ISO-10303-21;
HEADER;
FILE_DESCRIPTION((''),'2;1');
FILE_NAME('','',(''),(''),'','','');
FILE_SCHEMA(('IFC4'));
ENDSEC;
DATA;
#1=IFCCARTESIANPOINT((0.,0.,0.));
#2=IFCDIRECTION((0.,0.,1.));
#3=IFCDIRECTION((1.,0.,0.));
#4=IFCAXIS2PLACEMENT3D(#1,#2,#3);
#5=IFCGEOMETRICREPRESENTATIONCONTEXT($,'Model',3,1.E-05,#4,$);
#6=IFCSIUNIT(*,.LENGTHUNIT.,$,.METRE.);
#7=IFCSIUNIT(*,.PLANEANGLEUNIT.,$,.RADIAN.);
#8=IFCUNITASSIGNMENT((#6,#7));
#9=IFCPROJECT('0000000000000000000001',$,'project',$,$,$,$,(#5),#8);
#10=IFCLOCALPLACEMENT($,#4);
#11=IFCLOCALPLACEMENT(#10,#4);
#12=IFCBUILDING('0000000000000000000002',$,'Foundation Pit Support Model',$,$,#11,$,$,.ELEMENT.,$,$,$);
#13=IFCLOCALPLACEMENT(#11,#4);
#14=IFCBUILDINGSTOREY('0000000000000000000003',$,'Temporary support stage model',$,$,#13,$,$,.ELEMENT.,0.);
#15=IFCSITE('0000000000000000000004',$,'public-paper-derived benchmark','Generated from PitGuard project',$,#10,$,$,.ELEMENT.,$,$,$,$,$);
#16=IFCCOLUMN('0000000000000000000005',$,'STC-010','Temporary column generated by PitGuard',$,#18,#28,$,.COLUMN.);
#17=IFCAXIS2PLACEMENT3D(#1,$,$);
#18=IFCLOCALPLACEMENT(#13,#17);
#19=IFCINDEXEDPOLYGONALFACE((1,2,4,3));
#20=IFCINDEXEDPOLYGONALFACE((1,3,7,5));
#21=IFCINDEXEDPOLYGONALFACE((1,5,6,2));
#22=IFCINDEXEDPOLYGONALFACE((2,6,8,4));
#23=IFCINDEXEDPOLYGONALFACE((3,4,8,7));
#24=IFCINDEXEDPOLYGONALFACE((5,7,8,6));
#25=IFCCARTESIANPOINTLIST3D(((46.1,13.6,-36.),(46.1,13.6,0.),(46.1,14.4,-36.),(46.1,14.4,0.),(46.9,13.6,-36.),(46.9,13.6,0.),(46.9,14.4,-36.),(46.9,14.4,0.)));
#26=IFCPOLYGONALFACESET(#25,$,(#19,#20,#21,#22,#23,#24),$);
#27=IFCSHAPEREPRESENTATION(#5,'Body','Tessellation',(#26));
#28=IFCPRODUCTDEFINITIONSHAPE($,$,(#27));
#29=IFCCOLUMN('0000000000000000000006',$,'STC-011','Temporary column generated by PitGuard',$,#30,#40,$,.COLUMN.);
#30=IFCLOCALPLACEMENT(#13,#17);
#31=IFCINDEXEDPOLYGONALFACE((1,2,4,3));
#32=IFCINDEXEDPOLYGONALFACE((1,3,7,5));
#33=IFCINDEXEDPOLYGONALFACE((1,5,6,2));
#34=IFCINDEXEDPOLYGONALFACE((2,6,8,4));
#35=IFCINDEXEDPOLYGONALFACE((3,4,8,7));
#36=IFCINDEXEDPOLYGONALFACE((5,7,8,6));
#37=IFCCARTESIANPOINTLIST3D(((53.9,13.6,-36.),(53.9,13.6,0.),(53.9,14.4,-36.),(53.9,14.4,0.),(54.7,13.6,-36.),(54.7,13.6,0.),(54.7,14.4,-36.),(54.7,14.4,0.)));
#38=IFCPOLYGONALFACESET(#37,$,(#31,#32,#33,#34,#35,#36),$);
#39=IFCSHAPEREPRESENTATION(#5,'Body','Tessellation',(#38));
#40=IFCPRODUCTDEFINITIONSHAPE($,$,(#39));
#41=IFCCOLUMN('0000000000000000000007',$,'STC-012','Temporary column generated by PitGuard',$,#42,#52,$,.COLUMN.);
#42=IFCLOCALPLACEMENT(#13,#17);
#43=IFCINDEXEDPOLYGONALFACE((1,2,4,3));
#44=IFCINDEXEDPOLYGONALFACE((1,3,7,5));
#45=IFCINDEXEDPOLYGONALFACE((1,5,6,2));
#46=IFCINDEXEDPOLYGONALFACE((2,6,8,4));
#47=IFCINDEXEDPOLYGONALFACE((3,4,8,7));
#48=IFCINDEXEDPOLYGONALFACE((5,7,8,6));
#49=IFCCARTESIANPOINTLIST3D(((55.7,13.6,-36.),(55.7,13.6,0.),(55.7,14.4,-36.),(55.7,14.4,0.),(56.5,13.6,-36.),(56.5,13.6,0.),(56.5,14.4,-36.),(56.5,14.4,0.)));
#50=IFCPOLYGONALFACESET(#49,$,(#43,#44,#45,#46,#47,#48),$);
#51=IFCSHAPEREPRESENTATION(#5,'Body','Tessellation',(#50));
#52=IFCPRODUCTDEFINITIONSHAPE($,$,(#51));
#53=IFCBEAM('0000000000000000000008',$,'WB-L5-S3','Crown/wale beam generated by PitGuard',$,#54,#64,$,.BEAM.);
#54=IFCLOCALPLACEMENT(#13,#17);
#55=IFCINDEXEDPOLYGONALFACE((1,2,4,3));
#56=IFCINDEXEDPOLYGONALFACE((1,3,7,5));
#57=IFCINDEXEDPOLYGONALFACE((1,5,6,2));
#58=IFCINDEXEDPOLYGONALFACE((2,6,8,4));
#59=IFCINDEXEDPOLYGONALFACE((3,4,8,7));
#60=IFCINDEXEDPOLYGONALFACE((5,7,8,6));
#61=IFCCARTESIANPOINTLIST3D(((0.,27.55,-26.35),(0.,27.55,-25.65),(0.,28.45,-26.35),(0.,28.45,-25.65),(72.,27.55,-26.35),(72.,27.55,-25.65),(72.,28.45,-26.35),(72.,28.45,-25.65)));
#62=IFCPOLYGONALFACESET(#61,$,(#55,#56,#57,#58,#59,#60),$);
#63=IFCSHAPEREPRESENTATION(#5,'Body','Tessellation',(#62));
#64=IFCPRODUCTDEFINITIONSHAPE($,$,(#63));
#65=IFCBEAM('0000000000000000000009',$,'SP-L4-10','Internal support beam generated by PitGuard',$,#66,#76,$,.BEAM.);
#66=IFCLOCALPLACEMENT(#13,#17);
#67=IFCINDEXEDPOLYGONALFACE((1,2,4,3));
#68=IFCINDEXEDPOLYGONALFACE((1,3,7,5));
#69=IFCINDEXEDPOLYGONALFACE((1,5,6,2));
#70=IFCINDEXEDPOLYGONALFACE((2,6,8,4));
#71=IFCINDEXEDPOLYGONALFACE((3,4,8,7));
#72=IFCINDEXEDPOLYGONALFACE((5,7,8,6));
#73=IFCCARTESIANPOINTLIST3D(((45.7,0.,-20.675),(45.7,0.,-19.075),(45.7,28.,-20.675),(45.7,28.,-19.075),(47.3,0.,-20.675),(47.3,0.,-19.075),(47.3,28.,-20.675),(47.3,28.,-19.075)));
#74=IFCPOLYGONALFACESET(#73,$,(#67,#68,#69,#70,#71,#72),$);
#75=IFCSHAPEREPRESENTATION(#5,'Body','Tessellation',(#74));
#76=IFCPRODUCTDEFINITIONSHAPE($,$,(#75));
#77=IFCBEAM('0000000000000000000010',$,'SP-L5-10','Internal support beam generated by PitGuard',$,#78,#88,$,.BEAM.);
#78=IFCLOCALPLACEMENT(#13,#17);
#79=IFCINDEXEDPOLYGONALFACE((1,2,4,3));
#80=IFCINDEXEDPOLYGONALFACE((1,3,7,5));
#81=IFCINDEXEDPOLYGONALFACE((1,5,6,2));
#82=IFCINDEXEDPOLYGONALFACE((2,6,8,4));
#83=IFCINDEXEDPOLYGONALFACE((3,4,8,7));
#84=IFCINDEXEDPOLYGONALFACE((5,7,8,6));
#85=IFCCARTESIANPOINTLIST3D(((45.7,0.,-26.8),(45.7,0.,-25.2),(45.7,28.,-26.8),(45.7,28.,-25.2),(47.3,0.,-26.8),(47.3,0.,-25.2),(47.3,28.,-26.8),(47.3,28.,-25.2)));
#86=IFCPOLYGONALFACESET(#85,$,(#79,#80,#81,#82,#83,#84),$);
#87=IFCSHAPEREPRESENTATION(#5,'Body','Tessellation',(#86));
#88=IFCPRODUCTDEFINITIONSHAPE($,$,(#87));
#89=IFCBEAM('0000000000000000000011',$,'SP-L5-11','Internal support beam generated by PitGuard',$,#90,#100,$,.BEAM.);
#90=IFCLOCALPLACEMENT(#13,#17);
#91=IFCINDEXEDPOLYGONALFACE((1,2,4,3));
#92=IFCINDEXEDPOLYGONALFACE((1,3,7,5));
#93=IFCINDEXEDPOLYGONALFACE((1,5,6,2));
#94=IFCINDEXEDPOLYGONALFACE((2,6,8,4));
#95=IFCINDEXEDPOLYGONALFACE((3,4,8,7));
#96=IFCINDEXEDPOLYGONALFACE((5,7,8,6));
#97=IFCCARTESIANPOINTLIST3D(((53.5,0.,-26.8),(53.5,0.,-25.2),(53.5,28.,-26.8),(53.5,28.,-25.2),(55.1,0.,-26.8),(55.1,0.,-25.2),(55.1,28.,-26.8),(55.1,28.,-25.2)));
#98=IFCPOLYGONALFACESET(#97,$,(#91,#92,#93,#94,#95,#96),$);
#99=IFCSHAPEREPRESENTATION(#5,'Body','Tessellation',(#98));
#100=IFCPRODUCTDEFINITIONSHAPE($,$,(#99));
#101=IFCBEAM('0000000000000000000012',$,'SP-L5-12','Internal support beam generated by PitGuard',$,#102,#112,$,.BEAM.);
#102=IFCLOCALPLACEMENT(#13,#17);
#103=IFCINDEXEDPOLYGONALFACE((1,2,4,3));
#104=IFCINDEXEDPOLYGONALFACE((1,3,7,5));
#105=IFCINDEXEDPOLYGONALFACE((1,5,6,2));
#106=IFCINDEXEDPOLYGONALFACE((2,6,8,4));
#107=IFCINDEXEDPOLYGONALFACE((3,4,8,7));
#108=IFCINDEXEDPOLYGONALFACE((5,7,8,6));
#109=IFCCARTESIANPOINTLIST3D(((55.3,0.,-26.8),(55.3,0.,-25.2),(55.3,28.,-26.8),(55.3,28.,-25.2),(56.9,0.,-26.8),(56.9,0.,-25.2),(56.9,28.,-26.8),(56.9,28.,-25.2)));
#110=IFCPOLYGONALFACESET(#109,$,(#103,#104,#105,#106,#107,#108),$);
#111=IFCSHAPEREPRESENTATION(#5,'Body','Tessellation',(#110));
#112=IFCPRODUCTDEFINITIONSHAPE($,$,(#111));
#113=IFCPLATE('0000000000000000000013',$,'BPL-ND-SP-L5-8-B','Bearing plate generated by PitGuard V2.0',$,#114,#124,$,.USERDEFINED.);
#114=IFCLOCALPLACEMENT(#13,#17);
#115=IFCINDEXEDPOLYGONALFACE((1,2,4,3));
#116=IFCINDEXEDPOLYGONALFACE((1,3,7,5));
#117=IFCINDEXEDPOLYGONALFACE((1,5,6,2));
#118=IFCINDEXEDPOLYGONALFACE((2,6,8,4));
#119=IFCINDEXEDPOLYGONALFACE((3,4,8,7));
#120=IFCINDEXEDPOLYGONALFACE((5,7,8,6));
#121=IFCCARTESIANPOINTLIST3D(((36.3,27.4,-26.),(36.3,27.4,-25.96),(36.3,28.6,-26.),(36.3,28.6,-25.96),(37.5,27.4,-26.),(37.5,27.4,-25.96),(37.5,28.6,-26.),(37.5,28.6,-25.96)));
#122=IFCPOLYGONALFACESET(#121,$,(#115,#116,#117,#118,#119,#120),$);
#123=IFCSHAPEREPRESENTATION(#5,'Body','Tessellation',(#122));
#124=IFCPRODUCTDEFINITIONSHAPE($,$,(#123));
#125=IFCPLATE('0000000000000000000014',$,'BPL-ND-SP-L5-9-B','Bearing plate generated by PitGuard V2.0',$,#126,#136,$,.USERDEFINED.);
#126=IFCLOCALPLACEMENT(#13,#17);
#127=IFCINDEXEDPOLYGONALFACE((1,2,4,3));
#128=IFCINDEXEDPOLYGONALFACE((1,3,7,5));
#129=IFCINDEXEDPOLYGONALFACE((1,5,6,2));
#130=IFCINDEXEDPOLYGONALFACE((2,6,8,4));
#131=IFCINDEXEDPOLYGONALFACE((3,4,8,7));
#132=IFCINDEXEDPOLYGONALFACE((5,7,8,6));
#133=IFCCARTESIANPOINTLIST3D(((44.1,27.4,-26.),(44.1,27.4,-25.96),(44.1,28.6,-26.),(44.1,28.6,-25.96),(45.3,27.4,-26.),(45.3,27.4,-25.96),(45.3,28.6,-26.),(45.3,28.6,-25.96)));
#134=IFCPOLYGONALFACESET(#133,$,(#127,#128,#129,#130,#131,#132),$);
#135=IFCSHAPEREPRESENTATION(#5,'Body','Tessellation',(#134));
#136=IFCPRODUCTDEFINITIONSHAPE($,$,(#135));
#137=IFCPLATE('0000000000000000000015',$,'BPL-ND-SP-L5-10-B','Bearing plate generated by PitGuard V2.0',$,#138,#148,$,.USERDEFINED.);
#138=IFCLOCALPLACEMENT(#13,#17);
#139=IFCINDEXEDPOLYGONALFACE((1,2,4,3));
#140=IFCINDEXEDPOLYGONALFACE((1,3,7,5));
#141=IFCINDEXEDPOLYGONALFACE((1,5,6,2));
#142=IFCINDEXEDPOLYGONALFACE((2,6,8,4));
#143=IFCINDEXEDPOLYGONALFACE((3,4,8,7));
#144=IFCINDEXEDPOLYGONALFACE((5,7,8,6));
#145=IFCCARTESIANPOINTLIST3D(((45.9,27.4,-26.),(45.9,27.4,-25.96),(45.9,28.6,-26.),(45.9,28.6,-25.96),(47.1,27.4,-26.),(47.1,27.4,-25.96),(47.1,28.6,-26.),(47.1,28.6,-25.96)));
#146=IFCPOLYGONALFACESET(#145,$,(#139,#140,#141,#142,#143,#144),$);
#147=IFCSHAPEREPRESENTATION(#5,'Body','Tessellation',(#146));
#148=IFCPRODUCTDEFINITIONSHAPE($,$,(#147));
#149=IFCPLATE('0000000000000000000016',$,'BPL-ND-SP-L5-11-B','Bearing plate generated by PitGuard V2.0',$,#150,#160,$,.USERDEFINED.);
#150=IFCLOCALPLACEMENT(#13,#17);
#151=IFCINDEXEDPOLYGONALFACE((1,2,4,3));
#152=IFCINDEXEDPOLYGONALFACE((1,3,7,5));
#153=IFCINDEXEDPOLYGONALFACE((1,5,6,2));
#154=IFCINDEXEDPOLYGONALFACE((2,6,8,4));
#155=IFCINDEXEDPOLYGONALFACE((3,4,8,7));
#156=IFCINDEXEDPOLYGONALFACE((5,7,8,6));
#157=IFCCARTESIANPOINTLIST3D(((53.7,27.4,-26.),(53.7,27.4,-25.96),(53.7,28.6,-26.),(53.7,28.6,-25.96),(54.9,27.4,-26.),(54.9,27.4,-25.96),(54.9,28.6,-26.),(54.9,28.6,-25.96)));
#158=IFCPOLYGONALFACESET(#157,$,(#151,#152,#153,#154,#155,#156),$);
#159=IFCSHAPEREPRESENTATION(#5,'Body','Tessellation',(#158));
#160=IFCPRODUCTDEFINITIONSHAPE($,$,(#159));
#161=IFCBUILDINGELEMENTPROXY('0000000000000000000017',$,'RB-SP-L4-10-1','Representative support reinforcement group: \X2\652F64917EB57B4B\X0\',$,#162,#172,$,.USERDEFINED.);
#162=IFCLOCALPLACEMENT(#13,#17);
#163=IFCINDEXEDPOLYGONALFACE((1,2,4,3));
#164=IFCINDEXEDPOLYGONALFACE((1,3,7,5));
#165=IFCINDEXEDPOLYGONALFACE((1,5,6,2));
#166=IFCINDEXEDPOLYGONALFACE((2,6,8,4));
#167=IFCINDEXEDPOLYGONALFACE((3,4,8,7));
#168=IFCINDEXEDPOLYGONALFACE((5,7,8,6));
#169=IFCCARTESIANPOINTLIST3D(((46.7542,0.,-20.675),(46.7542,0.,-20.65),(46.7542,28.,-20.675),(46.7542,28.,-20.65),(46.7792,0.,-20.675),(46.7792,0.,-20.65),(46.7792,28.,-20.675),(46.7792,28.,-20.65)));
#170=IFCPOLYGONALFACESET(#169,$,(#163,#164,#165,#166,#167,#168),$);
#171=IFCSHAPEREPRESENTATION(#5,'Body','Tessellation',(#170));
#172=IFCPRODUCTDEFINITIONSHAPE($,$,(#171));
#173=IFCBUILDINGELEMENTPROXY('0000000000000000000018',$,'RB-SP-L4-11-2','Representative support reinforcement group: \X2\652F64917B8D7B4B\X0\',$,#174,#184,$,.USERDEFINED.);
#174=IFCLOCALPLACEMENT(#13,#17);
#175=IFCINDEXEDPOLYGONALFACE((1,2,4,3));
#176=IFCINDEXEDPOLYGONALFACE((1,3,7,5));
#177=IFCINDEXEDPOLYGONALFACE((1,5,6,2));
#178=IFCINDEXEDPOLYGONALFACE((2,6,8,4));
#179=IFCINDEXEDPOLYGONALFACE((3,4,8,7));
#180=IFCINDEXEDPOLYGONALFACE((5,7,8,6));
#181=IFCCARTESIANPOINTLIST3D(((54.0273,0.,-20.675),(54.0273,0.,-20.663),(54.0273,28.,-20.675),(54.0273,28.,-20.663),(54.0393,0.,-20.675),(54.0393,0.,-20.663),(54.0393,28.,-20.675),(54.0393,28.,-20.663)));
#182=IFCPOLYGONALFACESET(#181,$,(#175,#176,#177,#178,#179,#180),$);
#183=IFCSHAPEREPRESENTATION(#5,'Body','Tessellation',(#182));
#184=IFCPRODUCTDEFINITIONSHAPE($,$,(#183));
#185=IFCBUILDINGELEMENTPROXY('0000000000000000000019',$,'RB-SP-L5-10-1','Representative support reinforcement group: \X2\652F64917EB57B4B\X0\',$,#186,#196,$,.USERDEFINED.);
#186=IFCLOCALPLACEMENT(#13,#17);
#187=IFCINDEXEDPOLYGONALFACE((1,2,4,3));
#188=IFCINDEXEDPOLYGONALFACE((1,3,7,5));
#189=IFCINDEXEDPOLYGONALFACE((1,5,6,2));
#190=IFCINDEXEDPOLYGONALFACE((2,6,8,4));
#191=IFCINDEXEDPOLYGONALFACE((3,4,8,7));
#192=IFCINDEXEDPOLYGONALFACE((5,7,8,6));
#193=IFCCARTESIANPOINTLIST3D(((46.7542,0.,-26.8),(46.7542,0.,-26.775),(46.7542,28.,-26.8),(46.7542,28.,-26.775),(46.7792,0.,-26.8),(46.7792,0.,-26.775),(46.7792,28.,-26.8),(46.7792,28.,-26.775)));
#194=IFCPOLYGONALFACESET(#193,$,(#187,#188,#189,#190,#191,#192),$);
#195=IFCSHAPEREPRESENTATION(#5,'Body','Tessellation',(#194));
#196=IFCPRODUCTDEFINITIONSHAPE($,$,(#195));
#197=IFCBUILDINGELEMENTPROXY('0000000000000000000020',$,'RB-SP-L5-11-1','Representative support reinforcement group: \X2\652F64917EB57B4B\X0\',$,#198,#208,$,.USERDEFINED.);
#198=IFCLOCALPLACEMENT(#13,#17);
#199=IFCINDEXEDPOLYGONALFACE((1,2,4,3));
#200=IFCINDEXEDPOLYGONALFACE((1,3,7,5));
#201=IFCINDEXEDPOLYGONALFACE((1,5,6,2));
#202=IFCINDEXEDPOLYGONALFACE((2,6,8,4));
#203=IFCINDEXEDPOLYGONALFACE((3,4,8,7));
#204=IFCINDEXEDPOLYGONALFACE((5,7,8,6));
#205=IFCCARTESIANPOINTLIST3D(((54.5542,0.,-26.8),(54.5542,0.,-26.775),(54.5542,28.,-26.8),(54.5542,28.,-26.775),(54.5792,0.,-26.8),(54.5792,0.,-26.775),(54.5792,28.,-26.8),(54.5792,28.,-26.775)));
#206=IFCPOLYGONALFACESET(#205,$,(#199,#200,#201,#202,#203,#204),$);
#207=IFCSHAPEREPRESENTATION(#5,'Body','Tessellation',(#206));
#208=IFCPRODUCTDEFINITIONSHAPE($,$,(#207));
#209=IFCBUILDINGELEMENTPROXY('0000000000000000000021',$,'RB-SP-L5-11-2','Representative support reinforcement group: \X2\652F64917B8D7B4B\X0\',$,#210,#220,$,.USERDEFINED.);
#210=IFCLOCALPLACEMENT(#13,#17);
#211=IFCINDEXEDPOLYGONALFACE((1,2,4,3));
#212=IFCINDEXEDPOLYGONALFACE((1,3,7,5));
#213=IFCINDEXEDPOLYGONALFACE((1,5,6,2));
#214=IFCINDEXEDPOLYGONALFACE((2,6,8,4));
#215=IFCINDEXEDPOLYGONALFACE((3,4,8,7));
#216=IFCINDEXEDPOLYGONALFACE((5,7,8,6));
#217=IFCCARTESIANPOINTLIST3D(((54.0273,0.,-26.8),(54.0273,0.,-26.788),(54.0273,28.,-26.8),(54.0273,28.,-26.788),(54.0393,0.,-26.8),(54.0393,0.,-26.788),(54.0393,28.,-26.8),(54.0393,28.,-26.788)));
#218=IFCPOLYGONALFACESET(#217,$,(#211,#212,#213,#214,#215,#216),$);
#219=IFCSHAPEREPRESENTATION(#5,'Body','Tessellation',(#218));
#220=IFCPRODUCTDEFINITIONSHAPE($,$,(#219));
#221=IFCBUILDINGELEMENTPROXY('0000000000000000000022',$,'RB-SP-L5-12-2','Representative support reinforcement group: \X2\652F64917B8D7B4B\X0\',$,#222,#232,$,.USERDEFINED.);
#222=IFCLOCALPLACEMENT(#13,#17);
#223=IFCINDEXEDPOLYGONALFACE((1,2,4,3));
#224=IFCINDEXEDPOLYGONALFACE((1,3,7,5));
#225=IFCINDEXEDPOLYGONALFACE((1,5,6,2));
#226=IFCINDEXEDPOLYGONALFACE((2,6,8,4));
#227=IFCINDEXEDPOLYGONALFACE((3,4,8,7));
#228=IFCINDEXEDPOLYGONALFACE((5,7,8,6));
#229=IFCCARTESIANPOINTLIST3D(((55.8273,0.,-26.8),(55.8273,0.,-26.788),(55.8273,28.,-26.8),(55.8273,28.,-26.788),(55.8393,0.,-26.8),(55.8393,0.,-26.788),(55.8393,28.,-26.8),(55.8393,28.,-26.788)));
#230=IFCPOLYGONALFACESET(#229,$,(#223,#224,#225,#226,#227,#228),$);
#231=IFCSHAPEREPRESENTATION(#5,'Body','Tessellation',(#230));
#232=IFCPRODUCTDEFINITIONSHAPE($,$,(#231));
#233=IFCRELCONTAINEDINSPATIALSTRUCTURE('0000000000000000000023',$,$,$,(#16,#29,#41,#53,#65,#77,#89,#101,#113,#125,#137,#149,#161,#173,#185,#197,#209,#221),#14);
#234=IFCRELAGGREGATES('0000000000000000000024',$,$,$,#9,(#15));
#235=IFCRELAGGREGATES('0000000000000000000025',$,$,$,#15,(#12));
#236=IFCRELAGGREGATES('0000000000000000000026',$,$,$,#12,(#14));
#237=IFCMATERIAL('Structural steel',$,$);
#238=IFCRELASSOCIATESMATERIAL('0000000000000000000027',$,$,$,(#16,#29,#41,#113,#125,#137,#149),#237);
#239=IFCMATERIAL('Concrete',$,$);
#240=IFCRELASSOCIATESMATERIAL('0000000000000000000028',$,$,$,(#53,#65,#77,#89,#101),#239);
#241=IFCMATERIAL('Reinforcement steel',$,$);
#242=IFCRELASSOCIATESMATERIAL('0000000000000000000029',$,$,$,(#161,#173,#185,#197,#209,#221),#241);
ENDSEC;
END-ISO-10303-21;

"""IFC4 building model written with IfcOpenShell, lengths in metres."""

from ifc_helpers import new_model, si_unit, frame, origin_with_axes, origin_2d, place, context, project, spatial, rectangle, extrude, material, element, save


model = new_model("IFC4")

# Units and contexts
model_context = context("Model", 3, precision=1e-05, world=origin_with_axes())
ifc_project = project(units=[si_unit("LENGTHUNIT", "METRE"), si_unit("PLANEANGLEUNIT", "RADIAN")], contexts=[model_context])

# Site, building, storey
site_placement = place(None, origin_with_axes())
site = spatial("IfcSite", under=ifc_project, at=site_placement, Name="public-paper-derived benchmark", Description="Generated from PitGuard project", CompositionType="ELEMENT")
building_placement = place(site_placement, origin_with_axes())
building = spatial("IfcBuilding", under=site, at=building_placement, Name="Foundation Pit Support Model", CompositionType="ELEMENT")
storey_placement = place(building_placement, origin_with_axes())
storey = spatial("IfcBuildingStorey", under=building, at=storey_placement, Name="Temporary support stage model", CompositionType="ELEMENT", Elevation=0.0)

# Columns
ifc_material_1 = material(Name="Structural steel")
for number, where, z_axis, x_axis, name in (
    (1, (46.5, 14.0, -36.0), (0.0, 0.0, 1.0), (1.0, 0.0, 0.0), "STC-010"),
    (2, (54.3, 14.0, -36.0), (0.0, 0.0, 1.0), (1.0, 0.0, 0.0), "STC-011"),
    (3, (56.1, 14.0, -36.0), (0.0, 0.0, 1.0), (1.0, 0.0, 0.0), "STC-012"),
):
    element("IfcColumn", number, at=place(storey_placement, frame(where, z_axis=z_axis, x_axis=x_axis)), inside=storey, material=ifc_material_1, Name=name, Description="Temporary column generated by PitGuard", PredefinedType="COLUMN", context=model_context, shape_type="SweptSolid", body=[
        extrude(rectangle(XDim=0.8, YDim=0.8, at=origin_2d()), origin_with_axes(), (0.0, 0.0, 1.0), 36.0),
    ])

# Beams
ifc_material_2 = material(Name="Concrete")
beam_placement = place(storey_placement, frame((36.0, 28.0, -26.35), z_axis=(0.0, 0.0, 1.0), x_axis=(-1.0, 0.0, 0.0)))
element("IfcBeam", 4, at=beam_placement, inside=storey, material=ifc_material_2, Name="WB-L5-S3", Description="Crown/wale beam generated by PitGuard", PredefinedType="BEAM", context=model_context, shape_type="SweptSolid", body=[
    extrude(rectangle(XDim=72.0, YDim=0.9, at=origin_2d()), origin_with_axes(), (0.0, 0.0, 1.0), 0.7),
])
for number, where, z_axis, x_axis, name in (
    (5, (46.5, 14.0, -20.675), (0.0, 0.0, 1.0), (0.0, 1.0, 0.0), "SP-L4-10"),
    (6, (46.5, 14.0, -26.8), (0.0, 0.0, 1.0), (0.0, 1.0, 0.0), "SP-L5-10"),
    (7, (54.3, 14.0, -26.8), (0.0, 0.0, 1.0), (0.0, 1.0, 0.0), "SP-L5-11"),
    (8, (56.1, 14.0, -26.8), (0.0, 0.0, 1.0), (0.0, 1.0, 0.0), "SP-L5-12"),
):
    element("IfcBeam", number, at=place(storey_placement, frame(where, z_axis=z_axis, x_axis=x_axis)), inside=storey, material=ifc_material_2, Name=name, Description="Internal support beam generated by PitGuard", PredefinedType="BEAM", context=model_context, shape_type="SweptSolid", body=[
        extrude(rectangle(XDim=28.0, YDim=1.6, at=origin_2d()), origin_with_axes(), (0.0, 0.0, 1.0), 1.6),
    ])

# Plates
for number, where, z_axis, x_axis, name in (
    (9, (36.9, 28.0, -26.0), (0.0, 0.0, 1.0), (1.0, 0.0, 0.0), "BPL-ND-SP-L5-8-B"),
    (10, (44.7, 28.0, -26.0), (0.0, 0.0, 1.0), (1.0, 0.0, 0.0), "BPL-ND-SP-L5-9-B"),
    (11, (46.5, 28.0, -26.0), (0.0, 0.0, 1.0), (1.0, 0.0, 0.0), "BPL-ND-SP-L5-10-B"),
    (12, (54.3, 28.0, -26.0), (0.0, 0.0, 1.0), (1.0, 0.0, 0.0), "BPL-ND-SP-L5-11-B"),
):
    element("IfcPlate", number, at=place(storey_placement, frame(where, z_axis=z_axis, x_axis=x_axis)), inside=storey, material=ifc_material_1, Name=name, Description="Bearing plate generated by PitGuard V2.0", PredefinedType="USERDEFINED", context=model_context, shape_type="SweptSolid", body=[
        extrude(rectangle(XDim=1.2, YDim=1.2, at=origin_2d()), origin_with_axes(), (0.0, 0.0, 1.0), 0.04),
    ])

# Building element proxies
ifc_material_3 = material(Name="Reinforcement steel")
proxy_1_placement = place(storey_placement, frame((46.7667, 14.0, -20.675), z_axis=(0.0, 0.0, 1.0), x_axis=(0.0, 1.0, 0.0)))
element("IfcBuildingElementProxy", 13, at=proxy_1_placement, inside=storey, material=ifc_material_3, Name="RB-SP-L4-10-1", Description="Representative support reinforcement group: 支撑纵筋", PredefinedType="USERDEFINED", context=model_context, shape_type="SweptSolid", body=[
    extrude(rectangle(XDim=28.0, YDim=0.025, at=origin_2d()), origin_with_axes(), (0.0, 0.0, 1.0), 0.025),
])
proxy_2_placement = place(storey_placement, frame((54.0333, 14.0, -20.675), z_axis=(0.0, 0.0, 1.0), x_axis=(0.0, 1.0, 0.0)))
element("IfcBuildingElementProxy", 14, at=proxy_2_placement, inside=storey, material=ifc_material_3, Name="RB-SP-L4-11-2", Description="Representative support reinforcement group: 支撑箍筋", PredefinedType="USERDEFINED", context=model_context, shape_type="SweptSolid", body=[
    extrude(rectangle(XDim=28.0, YDim=0.012, at=origin_2d()), origin_with_axes(), (0.0, 0.0, 1.0), 0.012),
])
for number, where, z_axis, x_axis, name in (
    (15, (46.7667, 14.0, -26.8), (0.0, 0.0, 1.0), (0.0, 1.0, 0.0), "RB-SP-L5-10-1"),
    (16, (54.5667, 14.0, -26.8), (0.0, 0.0, 1.0), (0.0, 1.0, 0.0), "RB-SP-L5-11-1"),
):
    element("IfcBuildingElementProxy", number, at=place(storey_placement, frame(where, z_axis=z_axis, x_axis=x_axis)), inside=storey, material=ifc_material_3, Name=name, Description="Representative support reinforcement group: 支撑纵筋", PredefinedType="USERDEFINED", context=model_context, shape_type="SweptSolid", body=[
        extrude(rectangle(XDim=28.0, YDim=0.025, at=origin_2d()), origin_with_axes(), (0.0, 0.0, 1.0), 0.025),
    ])
for number, where, z_axis, x_axis, name in (
    (17, (54.0333, 14.0, -26.8), (0.0, 0.0, 1.0), (0.0, 1.0, 0.0), "RB-SP-L5-11-2"),
    (18, (55.8333, 14.0, -26.8), (0.0, 0.0, 1.0), (0.0, 1.0, 0.0), "RB-SP-L5-12-2"),
):
    element("IfcBuildingElementProxy", number, at=place(storey_placement, frame(where, z_axis=z_axis, x_axis=x_axis)), inside=storey, material=ifc_material_3, Name=name, Description="Representative support reinforcement group: 支撑箍筋", PredefinedType="USERDEFINED", context=model_context, shape_type="SweptSolid", body=[
        extrude(rectangle(XDim=28.0, YDim=0.012, at=origin_2d()), origin_with_axes(), (0.0, 0.0, 1.0), 0.012),
    ])

save(model, "model.ifc")
